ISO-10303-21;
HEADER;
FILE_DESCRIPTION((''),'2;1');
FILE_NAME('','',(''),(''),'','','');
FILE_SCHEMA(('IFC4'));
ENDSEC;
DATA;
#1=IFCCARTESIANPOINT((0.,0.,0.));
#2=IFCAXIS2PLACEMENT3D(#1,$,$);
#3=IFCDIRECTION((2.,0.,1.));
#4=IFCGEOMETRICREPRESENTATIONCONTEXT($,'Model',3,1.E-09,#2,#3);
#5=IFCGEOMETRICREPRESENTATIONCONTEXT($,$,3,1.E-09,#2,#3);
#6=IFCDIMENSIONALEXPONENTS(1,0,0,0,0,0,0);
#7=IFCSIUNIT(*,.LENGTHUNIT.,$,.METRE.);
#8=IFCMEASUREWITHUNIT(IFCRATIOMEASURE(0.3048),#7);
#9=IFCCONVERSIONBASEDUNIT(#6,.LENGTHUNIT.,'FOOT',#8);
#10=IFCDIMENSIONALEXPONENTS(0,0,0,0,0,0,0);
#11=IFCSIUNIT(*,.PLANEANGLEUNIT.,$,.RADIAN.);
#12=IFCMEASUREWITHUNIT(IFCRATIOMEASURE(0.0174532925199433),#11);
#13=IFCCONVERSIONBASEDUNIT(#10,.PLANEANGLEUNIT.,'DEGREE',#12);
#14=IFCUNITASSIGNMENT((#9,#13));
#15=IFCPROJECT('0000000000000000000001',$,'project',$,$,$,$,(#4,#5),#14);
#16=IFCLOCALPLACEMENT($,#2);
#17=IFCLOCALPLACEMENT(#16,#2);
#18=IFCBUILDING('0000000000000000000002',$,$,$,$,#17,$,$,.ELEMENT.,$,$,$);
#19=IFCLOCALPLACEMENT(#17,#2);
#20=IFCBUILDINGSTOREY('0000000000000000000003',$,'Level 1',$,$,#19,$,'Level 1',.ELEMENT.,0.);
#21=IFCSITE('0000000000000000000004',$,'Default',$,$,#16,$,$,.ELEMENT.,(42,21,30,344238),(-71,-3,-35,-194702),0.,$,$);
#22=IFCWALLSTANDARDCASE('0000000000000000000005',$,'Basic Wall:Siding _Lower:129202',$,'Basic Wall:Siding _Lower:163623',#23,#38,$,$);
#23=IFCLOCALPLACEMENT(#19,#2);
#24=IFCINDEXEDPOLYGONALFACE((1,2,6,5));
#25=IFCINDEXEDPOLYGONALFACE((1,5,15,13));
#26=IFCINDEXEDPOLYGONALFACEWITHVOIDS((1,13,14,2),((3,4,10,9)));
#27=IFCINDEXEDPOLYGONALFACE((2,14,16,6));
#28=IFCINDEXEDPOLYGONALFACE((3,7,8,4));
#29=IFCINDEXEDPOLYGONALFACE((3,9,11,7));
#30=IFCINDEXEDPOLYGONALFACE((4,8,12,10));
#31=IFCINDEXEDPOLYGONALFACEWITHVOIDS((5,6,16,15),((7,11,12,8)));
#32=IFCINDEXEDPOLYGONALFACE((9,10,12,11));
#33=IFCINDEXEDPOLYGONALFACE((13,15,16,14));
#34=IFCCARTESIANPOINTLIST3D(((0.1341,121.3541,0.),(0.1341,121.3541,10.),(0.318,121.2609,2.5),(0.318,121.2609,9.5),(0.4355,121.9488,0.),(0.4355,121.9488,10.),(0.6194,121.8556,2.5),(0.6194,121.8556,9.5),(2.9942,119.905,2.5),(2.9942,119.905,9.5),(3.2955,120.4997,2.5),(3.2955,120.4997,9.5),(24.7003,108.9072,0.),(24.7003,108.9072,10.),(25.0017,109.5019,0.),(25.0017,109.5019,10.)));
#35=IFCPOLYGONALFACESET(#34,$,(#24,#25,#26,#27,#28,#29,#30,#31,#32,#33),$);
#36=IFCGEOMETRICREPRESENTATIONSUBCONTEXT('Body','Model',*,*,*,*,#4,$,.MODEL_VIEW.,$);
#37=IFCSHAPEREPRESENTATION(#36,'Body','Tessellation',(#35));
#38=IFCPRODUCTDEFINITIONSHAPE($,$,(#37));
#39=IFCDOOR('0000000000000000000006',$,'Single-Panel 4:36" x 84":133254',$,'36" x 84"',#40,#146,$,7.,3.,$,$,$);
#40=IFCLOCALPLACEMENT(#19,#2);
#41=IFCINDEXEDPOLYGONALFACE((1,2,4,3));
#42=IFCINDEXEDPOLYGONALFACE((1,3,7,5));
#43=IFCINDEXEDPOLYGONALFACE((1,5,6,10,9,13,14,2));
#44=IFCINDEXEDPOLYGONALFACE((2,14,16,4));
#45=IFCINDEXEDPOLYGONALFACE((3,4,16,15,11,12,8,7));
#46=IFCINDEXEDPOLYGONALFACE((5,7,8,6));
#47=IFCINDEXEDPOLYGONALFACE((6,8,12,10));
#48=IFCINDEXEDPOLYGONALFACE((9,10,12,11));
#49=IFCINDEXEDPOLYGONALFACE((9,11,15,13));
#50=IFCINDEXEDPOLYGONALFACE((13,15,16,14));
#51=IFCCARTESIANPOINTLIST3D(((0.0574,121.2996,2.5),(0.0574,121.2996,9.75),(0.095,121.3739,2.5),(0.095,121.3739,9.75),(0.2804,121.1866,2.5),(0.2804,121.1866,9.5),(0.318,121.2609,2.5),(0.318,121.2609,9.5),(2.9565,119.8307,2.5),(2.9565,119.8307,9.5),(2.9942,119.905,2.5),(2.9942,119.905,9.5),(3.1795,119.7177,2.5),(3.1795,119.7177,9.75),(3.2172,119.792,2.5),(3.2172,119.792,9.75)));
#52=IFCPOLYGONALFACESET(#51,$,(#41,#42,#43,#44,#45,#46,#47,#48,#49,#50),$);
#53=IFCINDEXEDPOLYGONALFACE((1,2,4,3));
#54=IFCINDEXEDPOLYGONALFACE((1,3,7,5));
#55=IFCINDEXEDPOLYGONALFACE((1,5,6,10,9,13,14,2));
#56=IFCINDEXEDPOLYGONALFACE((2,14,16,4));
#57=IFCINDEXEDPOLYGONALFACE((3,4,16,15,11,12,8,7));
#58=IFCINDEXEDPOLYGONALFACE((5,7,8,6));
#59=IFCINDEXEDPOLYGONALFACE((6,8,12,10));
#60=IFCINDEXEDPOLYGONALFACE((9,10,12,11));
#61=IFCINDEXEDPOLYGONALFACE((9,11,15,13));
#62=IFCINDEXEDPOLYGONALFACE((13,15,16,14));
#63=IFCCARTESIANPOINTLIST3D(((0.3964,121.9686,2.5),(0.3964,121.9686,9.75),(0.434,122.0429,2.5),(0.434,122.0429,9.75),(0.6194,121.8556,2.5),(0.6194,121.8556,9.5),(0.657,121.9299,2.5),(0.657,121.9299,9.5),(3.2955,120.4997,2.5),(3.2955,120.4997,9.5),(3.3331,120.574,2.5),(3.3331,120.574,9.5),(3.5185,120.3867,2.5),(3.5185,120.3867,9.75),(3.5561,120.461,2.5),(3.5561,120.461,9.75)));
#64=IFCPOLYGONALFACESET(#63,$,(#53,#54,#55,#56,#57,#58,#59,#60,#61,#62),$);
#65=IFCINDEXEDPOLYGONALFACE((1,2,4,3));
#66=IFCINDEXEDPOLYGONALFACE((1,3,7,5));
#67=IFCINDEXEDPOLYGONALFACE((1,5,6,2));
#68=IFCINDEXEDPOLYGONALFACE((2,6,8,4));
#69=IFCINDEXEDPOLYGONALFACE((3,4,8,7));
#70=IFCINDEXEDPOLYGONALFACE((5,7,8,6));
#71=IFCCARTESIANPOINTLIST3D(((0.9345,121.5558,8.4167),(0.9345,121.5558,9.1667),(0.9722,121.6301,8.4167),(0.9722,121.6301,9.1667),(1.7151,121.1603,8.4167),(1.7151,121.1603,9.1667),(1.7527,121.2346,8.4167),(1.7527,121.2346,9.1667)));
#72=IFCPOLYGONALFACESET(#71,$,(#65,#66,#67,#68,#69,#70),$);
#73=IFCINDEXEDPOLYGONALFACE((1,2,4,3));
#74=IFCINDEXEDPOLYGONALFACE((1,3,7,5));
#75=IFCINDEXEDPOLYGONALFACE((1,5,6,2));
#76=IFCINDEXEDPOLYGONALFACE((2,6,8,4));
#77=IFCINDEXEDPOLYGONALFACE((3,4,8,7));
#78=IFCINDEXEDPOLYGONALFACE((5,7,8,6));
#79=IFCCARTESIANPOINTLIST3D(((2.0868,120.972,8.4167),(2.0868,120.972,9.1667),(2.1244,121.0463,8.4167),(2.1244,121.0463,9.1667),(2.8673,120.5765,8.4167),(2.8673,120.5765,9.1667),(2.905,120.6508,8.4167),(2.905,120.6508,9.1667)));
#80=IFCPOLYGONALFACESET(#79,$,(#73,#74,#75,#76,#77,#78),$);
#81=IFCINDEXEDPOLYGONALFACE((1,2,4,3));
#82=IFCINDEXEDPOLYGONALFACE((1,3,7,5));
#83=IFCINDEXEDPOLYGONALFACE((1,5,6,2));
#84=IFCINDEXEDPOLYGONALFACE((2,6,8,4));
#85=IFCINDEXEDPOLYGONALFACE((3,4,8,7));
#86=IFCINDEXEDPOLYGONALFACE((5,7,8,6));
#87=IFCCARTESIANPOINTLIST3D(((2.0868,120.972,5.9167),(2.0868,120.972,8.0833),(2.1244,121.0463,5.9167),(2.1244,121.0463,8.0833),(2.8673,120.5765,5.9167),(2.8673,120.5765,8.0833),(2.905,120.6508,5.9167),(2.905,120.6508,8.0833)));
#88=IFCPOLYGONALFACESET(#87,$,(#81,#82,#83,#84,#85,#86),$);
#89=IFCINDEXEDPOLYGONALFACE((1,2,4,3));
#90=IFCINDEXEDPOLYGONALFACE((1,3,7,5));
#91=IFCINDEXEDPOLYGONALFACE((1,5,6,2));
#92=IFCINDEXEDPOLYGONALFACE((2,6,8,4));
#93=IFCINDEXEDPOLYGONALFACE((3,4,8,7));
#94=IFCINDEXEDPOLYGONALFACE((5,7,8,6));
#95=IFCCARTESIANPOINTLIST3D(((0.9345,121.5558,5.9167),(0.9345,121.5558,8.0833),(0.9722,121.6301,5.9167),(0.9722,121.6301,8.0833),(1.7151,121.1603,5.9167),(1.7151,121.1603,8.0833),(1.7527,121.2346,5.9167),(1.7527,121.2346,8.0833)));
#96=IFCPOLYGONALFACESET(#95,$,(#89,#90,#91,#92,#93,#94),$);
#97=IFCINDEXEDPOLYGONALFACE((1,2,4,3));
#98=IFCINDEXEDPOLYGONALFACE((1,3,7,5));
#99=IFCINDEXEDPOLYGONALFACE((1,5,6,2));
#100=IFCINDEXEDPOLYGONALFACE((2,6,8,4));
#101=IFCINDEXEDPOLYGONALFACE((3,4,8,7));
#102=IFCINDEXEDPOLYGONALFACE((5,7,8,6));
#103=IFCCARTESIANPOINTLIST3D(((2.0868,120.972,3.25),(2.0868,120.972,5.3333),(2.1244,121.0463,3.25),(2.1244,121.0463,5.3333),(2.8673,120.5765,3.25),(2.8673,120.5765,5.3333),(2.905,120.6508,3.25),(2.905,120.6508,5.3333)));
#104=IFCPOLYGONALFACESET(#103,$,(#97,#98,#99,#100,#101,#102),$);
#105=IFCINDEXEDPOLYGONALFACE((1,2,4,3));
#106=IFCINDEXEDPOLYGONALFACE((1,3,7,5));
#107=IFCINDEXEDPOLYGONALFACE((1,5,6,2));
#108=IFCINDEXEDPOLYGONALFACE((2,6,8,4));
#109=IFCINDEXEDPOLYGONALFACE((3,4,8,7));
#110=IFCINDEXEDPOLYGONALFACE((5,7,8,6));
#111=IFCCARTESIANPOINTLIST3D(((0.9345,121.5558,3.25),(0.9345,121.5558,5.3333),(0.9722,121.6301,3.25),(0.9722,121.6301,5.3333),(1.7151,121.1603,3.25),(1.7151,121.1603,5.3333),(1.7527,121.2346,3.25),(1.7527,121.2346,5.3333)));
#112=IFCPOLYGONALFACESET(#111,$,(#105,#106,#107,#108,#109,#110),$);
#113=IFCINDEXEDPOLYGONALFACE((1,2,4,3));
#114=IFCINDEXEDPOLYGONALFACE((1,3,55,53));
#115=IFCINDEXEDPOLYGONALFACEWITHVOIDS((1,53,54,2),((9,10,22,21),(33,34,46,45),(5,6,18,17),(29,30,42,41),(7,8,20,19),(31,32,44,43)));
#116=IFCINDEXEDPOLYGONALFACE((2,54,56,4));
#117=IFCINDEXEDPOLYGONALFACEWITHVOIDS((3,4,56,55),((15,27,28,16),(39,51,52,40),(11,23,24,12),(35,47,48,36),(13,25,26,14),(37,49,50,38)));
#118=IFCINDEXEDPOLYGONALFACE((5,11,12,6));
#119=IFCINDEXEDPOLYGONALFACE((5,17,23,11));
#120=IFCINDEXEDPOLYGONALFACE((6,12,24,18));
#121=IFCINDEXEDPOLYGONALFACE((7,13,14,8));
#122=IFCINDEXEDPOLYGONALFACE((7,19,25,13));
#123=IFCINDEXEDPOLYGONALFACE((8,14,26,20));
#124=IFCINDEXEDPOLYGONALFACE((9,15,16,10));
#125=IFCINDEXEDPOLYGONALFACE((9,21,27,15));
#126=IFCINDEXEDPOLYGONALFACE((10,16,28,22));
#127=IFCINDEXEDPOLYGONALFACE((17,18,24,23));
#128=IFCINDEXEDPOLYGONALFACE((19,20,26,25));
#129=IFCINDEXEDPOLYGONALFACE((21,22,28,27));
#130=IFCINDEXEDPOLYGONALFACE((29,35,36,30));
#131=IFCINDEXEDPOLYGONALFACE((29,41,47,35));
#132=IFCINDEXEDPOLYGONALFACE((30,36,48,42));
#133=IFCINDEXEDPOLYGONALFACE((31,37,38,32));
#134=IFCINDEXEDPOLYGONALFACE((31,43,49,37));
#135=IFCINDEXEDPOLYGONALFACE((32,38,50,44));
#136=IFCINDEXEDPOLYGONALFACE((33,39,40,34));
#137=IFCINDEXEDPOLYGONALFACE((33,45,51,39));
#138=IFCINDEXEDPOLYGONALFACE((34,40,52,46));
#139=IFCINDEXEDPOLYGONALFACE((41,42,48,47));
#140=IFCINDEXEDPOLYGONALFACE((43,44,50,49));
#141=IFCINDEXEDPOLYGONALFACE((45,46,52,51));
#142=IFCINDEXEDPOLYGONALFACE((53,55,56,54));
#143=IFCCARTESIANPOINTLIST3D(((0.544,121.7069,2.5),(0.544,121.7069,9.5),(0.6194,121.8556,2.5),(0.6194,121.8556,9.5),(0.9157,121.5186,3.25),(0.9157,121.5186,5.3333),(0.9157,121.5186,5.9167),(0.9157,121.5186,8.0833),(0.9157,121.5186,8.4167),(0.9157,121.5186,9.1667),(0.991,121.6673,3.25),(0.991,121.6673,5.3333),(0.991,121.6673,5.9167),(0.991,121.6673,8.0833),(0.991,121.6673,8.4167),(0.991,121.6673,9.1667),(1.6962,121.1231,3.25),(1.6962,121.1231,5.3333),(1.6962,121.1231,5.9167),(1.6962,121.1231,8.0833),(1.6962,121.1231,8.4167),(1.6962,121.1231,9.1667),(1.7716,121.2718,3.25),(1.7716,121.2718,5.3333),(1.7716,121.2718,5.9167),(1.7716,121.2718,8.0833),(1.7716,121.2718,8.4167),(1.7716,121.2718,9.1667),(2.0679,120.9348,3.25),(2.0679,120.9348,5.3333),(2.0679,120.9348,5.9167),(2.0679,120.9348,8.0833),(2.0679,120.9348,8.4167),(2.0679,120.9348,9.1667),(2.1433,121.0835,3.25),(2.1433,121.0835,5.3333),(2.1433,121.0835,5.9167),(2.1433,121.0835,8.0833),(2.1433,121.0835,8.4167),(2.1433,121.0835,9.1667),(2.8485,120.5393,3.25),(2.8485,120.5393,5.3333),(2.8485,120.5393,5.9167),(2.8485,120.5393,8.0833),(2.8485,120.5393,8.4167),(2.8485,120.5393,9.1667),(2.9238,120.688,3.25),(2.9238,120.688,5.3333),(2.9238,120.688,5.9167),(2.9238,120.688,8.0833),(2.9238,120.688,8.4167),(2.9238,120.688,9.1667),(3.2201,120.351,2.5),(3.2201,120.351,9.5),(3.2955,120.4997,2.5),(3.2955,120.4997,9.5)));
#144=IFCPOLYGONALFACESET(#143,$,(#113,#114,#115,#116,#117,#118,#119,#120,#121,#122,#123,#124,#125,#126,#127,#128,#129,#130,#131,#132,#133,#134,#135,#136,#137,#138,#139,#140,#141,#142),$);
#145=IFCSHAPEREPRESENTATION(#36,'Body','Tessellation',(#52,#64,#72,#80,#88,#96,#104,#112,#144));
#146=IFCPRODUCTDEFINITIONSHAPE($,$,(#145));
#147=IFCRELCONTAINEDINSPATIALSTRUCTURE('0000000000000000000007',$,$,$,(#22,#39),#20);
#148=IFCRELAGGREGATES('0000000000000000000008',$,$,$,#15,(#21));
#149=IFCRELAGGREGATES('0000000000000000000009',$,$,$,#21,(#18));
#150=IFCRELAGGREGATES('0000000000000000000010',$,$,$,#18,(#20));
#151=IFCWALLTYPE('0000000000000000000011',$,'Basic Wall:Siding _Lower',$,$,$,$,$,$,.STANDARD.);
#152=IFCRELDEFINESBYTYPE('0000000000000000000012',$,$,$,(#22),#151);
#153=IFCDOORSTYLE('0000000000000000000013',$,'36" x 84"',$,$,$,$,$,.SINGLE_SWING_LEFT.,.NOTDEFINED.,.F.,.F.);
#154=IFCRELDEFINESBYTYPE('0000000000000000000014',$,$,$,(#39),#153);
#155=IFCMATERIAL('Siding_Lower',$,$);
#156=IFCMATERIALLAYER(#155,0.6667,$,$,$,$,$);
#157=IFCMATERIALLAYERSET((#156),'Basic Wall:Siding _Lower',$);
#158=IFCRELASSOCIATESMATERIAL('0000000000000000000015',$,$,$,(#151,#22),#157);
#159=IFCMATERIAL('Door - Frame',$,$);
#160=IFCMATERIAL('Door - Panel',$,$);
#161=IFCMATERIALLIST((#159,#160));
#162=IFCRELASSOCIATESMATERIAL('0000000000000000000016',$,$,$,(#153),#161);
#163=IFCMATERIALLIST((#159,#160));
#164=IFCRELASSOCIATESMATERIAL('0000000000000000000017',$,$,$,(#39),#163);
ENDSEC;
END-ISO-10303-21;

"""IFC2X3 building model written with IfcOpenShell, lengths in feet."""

from ifc_helpers import new_model, entity, si_unit, converted_unit, direction, frame, frame_2d, origin, place, context, subcontext, project, spatial, polyline, rectangle, outline, extrude, source, transform, mapped, material, material_list, layer, layer_set, layer_usage, type_object, type_shapes, element, fill, save


model = new_model("IFC2X3")

# Units and contexts
model_context = context("Model", 3, precision=1e-09, world=origin(), true_north=direction((2.0, 0.0, 1.0)))
context_of_model = context(None, 3, precision=1e-09, world=origin(), true_north=direction((2.0, 0.0, 1.0)))
body_context = subcontext(model_context, "Body", "Model", "MODEL_VIEW")
ifc_project = project(units=[converted_unit("LENGTHUNIT", "FOOT", entity("IfcRatioMeasure", 0.3048), si_unit("LENGTHUNIT", "METRE"), dimensions=[1, 0, 0, 0, 0, 0, 0]), converted_unit("PLANEANGLEUNIT", "DEGREE", entity("IfcRatioMeasure", 0.0174532925199433), si_unit("PLANEANGLEUNIT", "RADIAN"), dimensions=[0, 0, 0, 0, 0, 0, 0])], contexts=[model_context, context_of_model])

# Site, building, storey
site_placement = place(None, origin())
site = spatial("IfcSite", under=ifc_project, at=site_placement, Name="Default", CompositionType="ELEMENT", RefLatitude=(42, 21, 30, 344238), RefLongitude=(-71, -3, -35, -194702), RefElevation=0.0)
building_placement = place(site_placement, origin())
building = spatial("IfcBuilding", under=site, at=building_placement, CompositionType="ELEMENT")
storey_placement = place(building_placement, origin())
storey = spatial("IfcBuildingStorey", under=building, at=storey_placement, Name="Level 1", LongName="Level 1", CompositionType="ELEMENT", Elevation=0.0)

# Wall, opening, door
ifc_material_1 = material(Name="Siding_Lower")
ifc_layer = layer(ifc_material_1, 0.6667)
ifc_layer_set = layer_set([ifc_layer], Name="Basic Wall:Siding _Lower")
ifc_layer_usage = layer_usage(ifc_layer_set, "AXIS2", "NEGATIVE", 0.3333)
wall_type = type_object("IfcWallType", Name="Basic Wall:Siding _Lower", PredefinedType="STANDARD", material=ifc_layer_set)
wall_placement = place(storey_placement, frame((0.2848, 121.6514, 0.0), z_axis=(0.0, 0.0, 1.0), x_axis=(0.892035, -0.451966, 0.0)))
wall = element("IfcWallStandardCase", 1, at=wall_placement, inside=storey, type_object=wall_type, material=ifc_layer_usage, Name="Basic Wall:Siding _Lower:129202", ObjectType="Basic Wall:Siding _Lower:163623", context=body_context, shape_type="SweptSolid", body=[
    extrude(rectangle(XDim=27.5395, YDim=0.6667, at=frame_2d((13.7697, 0.0), x_axis=(-1.0, 0.0))), origin(), (0.0, 0.0, 1.0), 10.0),
])
opening_placement = place(wall_placement, frame((0.2062, -0.3333, 2.5)))
opening = element("IfcOpeningElement", 2, at=opening_placement, cuts=wall, ObjectType="Opening", context=body_context, shape_type="SweptSolid", body=[
    extrude(rectangle(XDim=3.0, YDim=7.0, at=frame_2d((3.5, 1.5), x_axis=(0.0, -1.0))), frame((0.0, 0.0, 0.0), z_axis=(0.0, 1.0, 0.0), x_axis=(0.0, 0.0, 1.0)), (0.0, 0.0, 1.0), 0.6667),
])
ifc_material_2 = material(Name="Door - Frame")
ifc_material_3 = material(Name="Door - Panel")
ifc_material_list_1 = material_list([ifc_material_2, ifc_material_3])
ifc_material_list_2 = material_list([ifc_material_2, ifc_material_3])
door_style = type_object("IfcDoorStyle", Name="36\" x 84\"", ConstructionType="NOTDEFINED", OperationType="SINGLE_SWING_LEFT", ParameterTakesPrecedence=False, Sizeable=False, material=ifc_material_list_2)
shared_shape_1 = source(origin(), body_context, "Body", "SweptSolid", [
    extrude(outline(polyline([(-3.5625, -1.75), (3.6875, -1.75), (3.6875, 1.75), (-3.5625, 1.75), (-3.5625, 1.5), (3.4375, 1.5), (3.4375, -1.5), (-3.5625, -1.5), (-3.5625, -1.75)])), frame((1.5, 0.0, 3.5625), z_axis=(0.0, -1.0, 0.0), x_axis=(0.0, 0.0, 1.0)), (0.0, 0.0, 1.0), 0.0833),
    extrude(outline(polyline([(-1.75, -3.5625), (-1.5, -3.5625), (-1.5, 3.4375), (1.5, 3.4375), (1.5, -3.5625), (1.75, -3.5625), (1.75, 3.6875), (-1.75, 3.6875), (-1.75, -3.5625)])), frame((1.5, 0.75, 3.5625), z_axis=(0.0, -1.0, 0.0), x_axis=(1.0, 0.0, 0.0)), (0.0, 0.0, 1.0), 0.0833),
    extrude(rectangle(XDim=0.875, YDim=0.0833, at=frame_2d((0.0, 0.0), x_axis=(1.0, 0.0))), frame((0.8542, 0.5833, 5.9167)), (0.0, 0.0, 1.0), 0.75),
    extrude(rectangle(XDim=0.875, YDim=0.0833, at=frame_2d((0.0, 0.0), x_axis=(1.0, 0.0))), frame((2.1458, 0.5833, 5.9167)), (0.0, 0.0, 1.0), 0.75),
    extrude(rectangle(XDim=0.875, YDim=0.0833, at=frame_2d((0.0, 0.0), x_axis=(1.0, 0.0))), frame((2.1458, 0.5833, 3.4167)), (0.0, 0.0, 1.0), 2.1667),
    extrude(rectangle(XDim=0.875, YDim=0.0833, at=frame_2d((0.0, 0.0), x_axis=(1.0, 0.0))), frame((0.8542, 0.5833, 3.4167)), (0.0, 0.0, 1.0), 2.1667),
    extrude(rectangle(XDim=0.875, YDim=0.0833, at=frame_2d((0.0, 0.0), x_axis=(1.0, 0.0))), frame((2.1458, 0.5833, 0.75)), (0.0, 0.0, 1.0), 2.0833),
    extrude(rectangle(XDim=0.875, YDim=0.0833, at=frame_2d((0.0, 0.0), x_axis=(1.0, 0.0))), frame((0.8542, 0.5833, 0.75)), (0.0, 0.0, 1.0), 2.0833),
    extrude(outline(polyline([(-3.5, -1.5), (3.5, -1.5), (3.5, 1.5), (-3.5, 1.5), (-3.5, -1.5)]), holes=[polyline([(-3.1667, 0.2083), (-3.1667, 1.0833), (-2.4167, 1.0833), (-2.4167, 0.2083), (-3.1667, 0.2083)]), polyline([(-3.1667, -1.0833), (-3.1667, -0.2083), (-2.4167, -0.2083), (-2.4167, -1.0833), (-3.1667, -1.0833)]), polyline([(-2.0833, 0.2083), (-2.0833, 1.0833), (0.0833, 1.0833), (0.0833, 0.2083), (-2.0833, 0.2083)]), polyline([(-2.0833, -1.0833), (-2.0833, -0.2083), (0.0833, -0.2083), (0.0833, -1.0833), (-2.0833, -1.0833)]), polyline([(0.6667, 0.2083), (0.6667, 1.0833), (2.75, 1.0833), (2.75, 0.2083), (0.6667, 0.2083)]), polyline([(0.6667, -1.0833), (0.6667, -0.2083), (2.75, -0.2083), (2.75, -1.0833), (0.6667, -1.0833)])]), frame((1.5, 0.6667, 3.5), z_axis=(0.0, -1.0, 0.0), x_axis=(0.0, 0.0, -1.0)), (0.0, 0.0, 1.0), 0.1667),
])
type_shapes(door_style, [shared_shape_1])
door_placement = place(opening_placement, origin())
door = element("IfcDoor", 3, at=door_placement, inside=storey, type_object=door_style, material=ifc_material_list_1, Name="Single-Panel 4:36\" x 84\":133254", ObjectType="36\" x 84\"", OverallHeight=7.0, OverallWidth=3.0, context=body_context, shape_type="MappedRepresentation", body=[
    mapped(shared_shape_1, transform((0.0, 0.0, 0.0), scale=1.0)),
])
fill(opening, door)

save(model, "model.ifc")
